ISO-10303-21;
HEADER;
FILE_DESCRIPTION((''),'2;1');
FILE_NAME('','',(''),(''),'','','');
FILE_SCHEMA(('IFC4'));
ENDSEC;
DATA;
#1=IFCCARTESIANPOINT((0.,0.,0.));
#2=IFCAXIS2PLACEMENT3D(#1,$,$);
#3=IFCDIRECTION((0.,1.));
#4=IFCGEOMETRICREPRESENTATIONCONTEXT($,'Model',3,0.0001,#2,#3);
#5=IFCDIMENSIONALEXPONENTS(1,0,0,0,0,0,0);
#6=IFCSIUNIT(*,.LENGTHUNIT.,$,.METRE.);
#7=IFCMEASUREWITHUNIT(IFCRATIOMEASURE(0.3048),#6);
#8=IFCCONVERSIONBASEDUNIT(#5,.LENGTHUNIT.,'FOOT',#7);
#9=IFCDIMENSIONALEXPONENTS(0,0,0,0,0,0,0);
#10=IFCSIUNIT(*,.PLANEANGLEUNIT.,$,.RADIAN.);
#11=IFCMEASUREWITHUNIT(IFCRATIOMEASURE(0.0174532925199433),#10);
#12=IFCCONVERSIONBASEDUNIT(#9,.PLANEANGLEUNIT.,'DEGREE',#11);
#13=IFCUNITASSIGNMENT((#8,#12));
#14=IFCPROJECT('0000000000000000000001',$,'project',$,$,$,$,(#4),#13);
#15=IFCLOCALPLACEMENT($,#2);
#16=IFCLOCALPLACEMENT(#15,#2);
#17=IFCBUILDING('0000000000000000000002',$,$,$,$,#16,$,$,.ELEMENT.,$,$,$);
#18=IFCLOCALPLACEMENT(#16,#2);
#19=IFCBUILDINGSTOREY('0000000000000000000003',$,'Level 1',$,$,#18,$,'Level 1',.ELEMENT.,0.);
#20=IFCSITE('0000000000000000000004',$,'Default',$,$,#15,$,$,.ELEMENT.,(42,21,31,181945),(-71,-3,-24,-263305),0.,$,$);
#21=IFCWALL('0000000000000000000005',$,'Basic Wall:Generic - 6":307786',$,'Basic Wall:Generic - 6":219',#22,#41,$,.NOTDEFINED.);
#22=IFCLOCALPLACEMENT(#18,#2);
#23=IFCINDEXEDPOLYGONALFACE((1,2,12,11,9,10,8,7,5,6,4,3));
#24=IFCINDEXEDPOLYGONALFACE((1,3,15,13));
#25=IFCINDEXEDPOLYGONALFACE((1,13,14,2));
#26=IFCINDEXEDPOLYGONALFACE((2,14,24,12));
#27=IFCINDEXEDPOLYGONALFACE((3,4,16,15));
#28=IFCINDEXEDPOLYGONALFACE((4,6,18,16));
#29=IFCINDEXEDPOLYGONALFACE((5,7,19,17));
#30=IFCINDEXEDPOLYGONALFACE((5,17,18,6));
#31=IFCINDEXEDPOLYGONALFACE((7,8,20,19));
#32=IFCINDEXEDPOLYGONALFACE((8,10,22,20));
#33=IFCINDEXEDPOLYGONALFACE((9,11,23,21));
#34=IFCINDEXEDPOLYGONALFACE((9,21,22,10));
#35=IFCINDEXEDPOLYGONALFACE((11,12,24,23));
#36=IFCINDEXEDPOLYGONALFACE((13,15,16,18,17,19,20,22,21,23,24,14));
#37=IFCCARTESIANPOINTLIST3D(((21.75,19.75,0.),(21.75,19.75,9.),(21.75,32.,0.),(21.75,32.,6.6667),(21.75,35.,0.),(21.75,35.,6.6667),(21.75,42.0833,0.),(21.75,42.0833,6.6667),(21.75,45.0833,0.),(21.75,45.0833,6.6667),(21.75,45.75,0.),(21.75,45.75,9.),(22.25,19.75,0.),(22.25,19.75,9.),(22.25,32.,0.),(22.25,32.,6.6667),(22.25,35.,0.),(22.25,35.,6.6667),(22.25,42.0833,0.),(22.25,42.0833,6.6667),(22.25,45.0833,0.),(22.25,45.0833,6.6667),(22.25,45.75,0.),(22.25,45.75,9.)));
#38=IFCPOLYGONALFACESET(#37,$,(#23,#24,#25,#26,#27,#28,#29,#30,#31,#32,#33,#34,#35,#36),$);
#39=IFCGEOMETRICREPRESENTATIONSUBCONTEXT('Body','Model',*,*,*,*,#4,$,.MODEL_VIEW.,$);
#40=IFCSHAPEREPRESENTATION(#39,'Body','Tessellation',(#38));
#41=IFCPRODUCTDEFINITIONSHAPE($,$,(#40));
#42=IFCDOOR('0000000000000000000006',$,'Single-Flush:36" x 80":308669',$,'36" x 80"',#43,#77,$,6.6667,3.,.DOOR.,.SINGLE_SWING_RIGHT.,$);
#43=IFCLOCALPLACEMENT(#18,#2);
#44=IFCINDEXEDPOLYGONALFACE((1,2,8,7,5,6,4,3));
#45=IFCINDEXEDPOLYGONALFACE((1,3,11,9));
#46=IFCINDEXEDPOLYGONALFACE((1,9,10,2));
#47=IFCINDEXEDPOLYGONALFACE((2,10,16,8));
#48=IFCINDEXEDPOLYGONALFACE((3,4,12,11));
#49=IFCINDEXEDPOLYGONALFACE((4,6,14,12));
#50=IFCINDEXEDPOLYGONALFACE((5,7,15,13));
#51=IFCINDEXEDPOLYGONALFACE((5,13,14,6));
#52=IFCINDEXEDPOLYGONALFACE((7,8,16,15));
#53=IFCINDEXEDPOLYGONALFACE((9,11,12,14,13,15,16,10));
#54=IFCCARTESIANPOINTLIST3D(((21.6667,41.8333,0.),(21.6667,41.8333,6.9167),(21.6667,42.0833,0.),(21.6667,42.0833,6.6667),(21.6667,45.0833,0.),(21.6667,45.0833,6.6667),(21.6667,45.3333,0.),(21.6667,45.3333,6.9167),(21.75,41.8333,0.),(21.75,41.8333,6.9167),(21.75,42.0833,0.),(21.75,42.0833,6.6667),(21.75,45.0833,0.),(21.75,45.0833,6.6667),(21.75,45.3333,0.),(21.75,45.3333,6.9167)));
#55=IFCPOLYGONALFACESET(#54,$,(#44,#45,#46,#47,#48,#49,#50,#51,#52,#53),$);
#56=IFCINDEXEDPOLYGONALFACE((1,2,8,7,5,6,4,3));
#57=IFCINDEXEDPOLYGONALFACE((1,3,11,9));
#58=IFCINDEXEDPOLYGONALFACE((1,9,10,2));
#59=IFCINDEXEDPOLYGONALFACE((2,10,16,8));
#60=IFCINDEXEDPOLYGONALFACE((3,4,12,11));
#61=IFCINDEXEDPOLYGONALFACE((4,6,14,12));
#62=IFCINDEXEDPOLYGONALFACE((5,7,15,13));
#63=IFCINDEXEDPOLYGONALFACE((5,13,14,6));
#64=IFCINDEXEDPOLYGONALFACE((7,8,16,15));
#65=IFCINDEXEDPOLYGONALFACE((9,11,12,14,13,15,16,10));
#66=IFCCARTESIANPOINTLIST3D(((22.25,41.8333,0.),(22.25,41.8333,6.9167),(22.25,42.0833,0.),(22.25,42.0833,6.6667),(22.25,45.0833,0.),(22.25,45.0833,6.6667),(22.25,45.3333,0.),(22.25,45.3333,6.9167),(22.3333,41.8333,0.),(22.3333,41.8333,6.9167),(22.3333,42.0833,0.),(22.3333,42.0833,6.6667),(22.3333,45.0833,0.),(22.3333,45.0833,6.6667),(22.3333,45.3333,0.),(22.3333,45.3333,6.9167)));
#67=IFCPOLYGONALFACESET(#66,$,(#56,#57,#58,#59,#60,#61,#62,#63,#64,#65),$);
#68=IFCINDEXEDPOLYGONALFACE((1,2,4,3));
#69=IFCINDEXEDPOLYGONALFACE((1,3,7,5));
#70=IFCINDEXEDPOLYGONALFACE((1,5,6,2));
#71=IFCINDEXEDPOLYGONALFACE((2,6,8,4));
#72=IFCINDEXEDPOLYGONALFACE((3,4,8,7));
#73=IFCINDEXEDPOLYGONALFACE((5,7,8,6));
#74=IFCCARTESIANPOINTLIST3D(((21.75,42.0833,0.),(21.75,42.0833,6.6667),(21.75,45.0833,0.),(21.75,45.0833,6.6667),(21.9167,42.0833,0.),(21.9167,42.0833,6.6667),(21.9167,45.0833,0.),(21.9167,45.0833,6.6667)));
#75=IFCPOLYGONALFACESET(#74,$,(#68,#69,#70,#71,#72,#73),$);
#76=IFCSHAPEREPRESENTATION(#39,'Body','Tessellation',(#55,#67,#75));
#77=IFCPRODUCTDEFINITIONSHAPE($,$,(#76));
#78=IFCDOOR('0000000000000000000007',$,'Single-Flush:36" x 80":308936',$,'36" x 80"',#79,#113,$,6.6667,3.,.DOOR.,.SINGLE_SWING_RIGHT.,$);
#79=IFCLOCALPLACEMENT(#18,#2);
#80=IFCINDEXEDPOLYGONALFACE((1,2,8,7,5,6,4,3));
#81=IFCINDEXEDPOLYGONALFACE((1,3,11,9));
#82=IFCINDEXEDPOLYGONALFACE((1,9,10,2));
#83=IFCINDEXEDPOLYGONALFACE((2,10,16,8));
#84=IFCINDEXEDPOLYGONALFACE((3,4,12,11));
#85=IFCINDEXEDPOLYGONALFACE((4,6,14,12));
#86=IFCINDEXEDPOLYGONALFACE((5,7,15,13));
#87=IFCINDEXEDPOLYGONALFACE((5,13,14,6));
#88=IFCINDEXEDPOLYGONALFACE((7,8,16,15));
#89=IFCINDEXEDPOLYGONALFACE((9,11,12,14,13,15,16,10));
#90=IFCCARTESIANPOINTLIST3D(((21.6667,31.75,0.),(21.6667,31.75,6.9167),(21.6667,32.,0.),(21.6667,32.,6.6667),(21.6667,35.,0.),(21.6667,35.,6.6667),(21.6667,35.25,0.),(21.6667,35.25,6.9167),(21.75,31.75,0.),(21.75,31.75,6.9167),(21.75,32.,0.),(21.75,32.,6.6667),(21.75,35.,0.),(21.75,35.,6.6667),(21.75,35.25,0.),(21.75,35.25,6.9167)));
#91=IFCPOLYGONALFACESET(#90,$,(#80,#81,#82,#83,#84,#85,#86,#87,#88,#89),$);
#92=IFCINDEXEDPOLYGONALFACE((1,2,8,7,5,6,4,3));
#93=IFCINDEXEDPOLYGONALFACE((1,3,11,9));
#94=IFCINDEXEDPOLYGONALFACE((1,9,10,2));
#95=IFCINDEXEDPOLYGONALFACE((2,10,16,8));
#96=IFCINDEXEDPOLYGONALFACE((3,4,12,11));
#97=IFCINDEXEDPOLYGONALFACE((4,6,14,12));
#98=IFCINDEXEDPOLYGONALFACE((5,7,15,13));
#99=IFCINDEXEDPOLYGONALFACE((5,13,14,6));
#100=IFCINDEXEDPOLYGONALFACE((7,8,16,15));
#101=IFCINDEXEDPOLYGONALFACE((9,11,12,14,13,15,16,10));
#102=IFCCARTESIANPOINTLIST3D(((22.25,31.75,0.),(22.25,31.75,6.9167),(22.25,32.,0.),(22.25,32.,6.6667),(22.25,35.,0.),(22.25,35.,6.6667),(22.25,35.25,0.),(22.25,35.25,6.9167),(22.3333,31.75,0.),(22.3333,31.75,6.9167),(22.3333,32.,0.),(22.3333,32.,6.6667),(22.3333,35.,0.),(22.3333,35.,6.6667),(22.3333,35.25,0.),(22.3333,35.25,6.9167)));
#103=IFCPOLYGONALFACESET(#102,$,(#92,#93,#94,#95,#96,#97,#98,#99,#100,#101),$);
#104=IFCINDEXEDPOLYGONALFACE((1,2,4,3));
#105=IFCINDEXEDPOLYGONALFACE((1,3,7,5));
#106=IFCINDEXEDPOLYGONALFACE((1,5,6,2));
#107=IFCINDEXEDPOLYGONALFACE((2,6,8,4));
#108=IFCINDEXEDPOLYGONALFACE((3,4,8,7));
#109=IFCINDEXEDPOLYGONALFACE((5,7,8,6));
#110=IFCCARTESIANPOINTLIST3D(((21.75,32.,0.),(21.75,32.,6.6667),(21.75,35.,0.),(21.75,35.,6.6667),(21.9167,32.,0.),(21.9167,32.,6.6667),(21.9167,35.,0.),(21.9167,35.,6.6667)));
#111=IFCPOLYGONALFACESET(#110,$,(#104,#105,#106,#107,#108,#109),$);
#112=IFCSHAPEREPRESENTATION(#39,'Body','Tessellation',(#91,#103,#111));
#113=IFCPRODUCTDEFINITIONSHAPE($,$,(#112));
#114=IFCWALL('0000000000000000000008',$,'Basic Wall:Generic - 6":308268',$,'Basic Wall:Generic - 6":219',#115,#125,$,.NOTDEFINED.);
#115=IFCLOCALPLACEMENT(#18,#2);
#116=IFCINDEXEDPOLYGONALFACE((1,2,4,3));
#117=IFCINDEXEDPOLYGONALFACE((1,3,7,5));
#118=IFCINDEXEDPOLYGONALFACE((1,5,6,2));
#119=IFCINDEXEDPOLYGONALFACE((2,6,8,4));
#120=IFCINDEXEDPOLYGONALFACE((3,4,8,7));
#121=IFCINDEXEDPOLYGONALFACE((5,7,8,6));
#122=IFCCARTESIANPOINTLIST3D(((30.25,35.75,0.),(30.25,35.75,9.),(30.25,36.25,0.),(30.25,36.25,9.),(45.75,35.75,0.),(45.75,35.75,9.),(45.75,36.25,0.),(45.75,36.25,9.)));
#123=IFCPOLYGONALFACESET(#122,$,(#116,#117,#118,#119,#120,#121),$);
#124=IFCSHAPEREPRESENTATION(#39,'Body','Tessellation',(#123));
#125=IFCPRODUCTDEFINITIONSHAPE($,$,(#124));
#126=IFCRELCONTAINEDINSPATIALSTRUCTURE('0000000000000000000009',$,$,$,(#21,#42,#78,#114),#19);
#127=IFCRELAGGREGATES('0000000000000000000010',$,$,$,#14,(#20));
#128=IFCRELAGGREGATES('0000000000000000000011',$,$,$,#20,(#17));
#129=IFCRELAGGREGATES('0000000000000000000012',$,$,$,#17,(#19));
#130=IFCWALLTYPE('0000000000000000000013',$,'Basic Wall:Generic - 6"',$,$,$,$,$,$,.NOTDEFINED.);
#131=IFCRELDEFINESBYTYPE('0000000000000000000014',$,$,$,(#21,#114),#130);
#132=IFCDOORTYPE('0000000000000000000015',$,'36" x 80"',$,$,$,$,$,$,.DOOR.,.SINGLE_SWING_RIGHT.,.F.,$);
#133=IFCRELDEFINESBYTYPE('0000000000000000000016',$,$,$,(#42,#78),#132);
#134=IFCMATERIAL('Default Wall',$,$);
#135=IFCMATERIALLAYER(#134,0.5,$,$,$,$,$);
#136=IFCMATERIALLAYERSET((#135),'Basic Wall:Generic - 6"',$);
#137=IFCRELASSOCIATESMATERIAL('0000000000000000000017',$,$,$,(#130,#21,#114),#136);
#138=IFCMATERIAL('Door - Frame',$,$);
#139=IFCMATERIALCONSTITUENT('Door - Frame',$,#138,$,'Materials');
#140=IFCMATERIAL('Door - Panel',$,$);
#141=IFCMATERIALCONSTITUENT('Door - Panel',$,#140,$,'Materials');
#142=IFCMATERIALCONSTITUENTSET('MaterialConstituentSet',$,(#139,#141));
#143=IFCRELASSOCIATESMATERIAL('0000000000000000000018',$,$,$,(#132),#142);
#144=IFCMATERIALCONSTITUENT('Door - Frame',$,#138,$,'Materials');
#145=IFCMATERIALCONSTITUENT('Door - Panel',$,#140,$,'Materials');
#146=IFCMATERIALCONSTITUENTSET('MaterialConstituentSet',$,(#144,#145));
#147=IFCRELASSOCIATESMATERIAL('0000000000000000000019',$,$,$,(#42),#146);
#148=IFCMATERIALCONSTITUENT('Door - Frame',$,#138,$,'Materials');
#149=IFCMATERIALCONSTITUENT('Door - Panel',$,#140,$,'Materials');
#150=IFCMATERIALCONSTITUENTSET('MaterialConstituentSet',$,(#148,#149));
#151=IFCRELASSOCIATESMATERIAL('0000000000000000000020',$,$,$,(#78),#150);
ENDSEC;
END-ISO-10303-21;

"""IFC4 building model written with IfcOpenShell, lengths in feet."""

from ifc_helpers import new_model, entity, si_unit, converted_unit, direction, frame, frame_2d, origin, origin_2d_with_axis, place, context, subcontext, project, spatial, polyline, rectangle, outline, extrude, clip, bounded_halfspace, source, transform, mapped, material, layer, layer_set, layer_usage, constituent, constituent_set, type_object, type_shapes, element, fill, save


model = new_model("IFC4")

# Units and contexts
model_context = context("Model", 3, precision=0.0001, world=origin(), true_north=direction((0.0, 1.0)))
body_context = subcontext(model_context, "Body", "Model", "MODEL_VIEW")
ifc_project = project(units=[converted_unit("LENGTHUNIT", "FOOT", entity("IfcRatioMeasure", 0.3048), si_unit("LENGTHUNIT", "METRE"), dimensions=[1, 0, 0, 0, 0, 0, 0]), converted_unit("PLANEANGLEUNIT", "DEGREE", entity("IfcRatioMeasure", 0.0174532925199433), si_unit("PLANEANGLEUNIT", "RADIAN"), dimensions=[0, 0, 0, 0, 0, 0, 0])], contexts=[model_context])

# Site, building, storey
site_placement = place(None, origin())
site = spatial("IfcSite", under=ifc_project, at=site_placement, Name="Default", CompositionType="ELEMENT", RefLatitude=(42, 21, 31, 181945), RefLongitude=(-71, -3, -24, -263305), RefElevation=0.0)
building_placement = place(site_placement, origin())
building = spatial("IfcBuilding", under=site, at=building_placement, CompositionType="ELEMENT")
storey_placement = place(building_placement, origin())
storey = spatial("IfcBuildingStorey", under=building, at=storey_placement, Name="Level 1", LongName="Level 1", CompositionType="ELEMENT", Elevation=0.0)

# Shared definitions
ifc_material_1 = material(Name="Default Wall")
ifc_layer = layer(ifc_material_1, 0.5)
ifc_layer_set = layer_set([ifc_layer], Name="Basic Wall:Generic - 6\"")
wall_type = type_object("IfcWallType", Name="Basic Wall:Generic - 6\"", PredefinedType="NOTDEFINED", material=ifc_layer_set)
ifc_material_2 = material(Name="Door - Frame")
ifc_material_3 = material(Name="Door - Panel")
ifc_constituent_1 = constituent(ifc_material_2, Name="Door - Frame", Category="Materials")
ifc_constituent_2 = constituent(ifc_material_3, Name="Door - Panel", Category="Materials")
ifc_constituent_set_1 = constituent_set(constituents=[ifc_constituent_1, ifc_constituent_2], Name="MaterialConstituentSet")
door_type_1 = type_object("IfcDoorType", Name="36\" x 80\"", OperationType="SINGLE_SWING_RIGHT", ParameterTakesPrecedence=False, PredefinedType="DOOR", material=ifc_constituent_set_1)
shared_shape_1 = source(origin(), body_context, "Body", "SweptSolid", [
    extrude(outline(polyline([(-1.75, -3.5208), (1.75, -3.5208), (1.75, 3.3958), (1.5, 3.3958), (1.5, -3.2708), (-1.5, -3.2708), (-1.5, 3.3958), (-1.75, 3.3958), (-1.75, -3.5208)])), frame((1.5, 0.5, 3.3958), z_axis=(0.0, 1.0, 0.0), x_axis=(1.0, 0.0, 0.0)), (0.0, 0.0, 1.0), 0.0833),
    extrude(outline(polyline([(-3.5208, -1.75), (3.3958, -1.75), (3.3958, -1.5), (-3.2708, -1.5), (-3.2708, 1.5), (3.3958, 1.5), (3.3958, 1.75), (-3.5208, 1.75), (-3.5208, -1.75)])), frame((1.5, -0.0833, 3.3958), z_axis=(0.0, 1.0, 0.0), x_axis=(0.0, 0.0, -1.0)), (0.0, 0.0, 1.0), 0.0833),
    extrude(rectangle(XDim=0.1667, YDim=3.0, at=origin_2d_with_axis()), frame((1.5, 0.4167, 0.0), z_axis=(0.0, 0.0, 1.0), x_axis=(0.0, 1.0, 0.0)), (0.0, 0.0, 1.0), 6.6667),
])
type_shapes(door_type_1, [shared_shape_1])

# Wall, openings, doors
ifc_layer_usage_1 = layer_usage(ifc_layer_set, "AXIS2", "NEGATIVE", 0.25)
wall_1_placement = place(storey_placement, frame((22.0, 45.75, 0.0), z_axis=(0.0, 0.0, 1.0), x_axis=(0.0, -1.0, 0.0)))
wall_1 = element("IfcWall", 1, at=wall_1_placement, inside=storey, type_object=wall_type, material=ifc_layer_usage_1, Name="Basic Wall:Generic - 6\":307786", ObjectType="Basic Wall:Generic - 6\":219", PredefinedType="NOTDEFINED", context=body_context, shape_type="Clipping", body=[
    clip(clip(extrude(rectangle(XDim=26.0, YDim=0.5, at=frame_2d((13.0, 0.0), x_axis=(-1.0, 0.0))), origin(), (0.0, 0.0, 1.0), 9.0), bounded_halfspace(frame((10.0, -0.25, 9.0), z_axis=(0.0, 0.0, -1.0), x_axis=(0.0, -1.0, 0.0)), True, frame((10.0, -0.25, 9.0)), polyline([(0.0, 0.0), (0.0, 0.5), (-10.0, 0.5), (-10.0, 0.0), (-0.5, 0.0), (0.0, 0.0)]))), bounded_halfspace(frame((10.0, -0.25, 9.0), z_axis=(0.0, 0.0, -1.0), x_axis=(-1.0, 0.0, 0.0)), True, frame((10.0, -0.25, 9.0)), polyline([(0.0, 0.0), (15.5, 0.0), (16.0, 0.0), (16.0, 0.5), (0.0, 0.5), (0.0, 0.0)]))),
])
opening_1_placement = place(wall_1_placement, frame((3.6667, 0.25, 0.0)))
opening_1 = element("IfcOpeningElement", 2, at=opening_1_placement, cuts=wall_1, ObjectType="Opening", PredefinedType="OPENING", context=body_context, shape_type="SweptSolid", body=[
    extrude(rectangle(XDim=3.0, YDim=6.6667, at=frame_2d((3.3333, 1.5), x_axis=(0.0, 1.0))), frame((0.0, 0.0, 0.0), z_axis=(0.0, -1.0, 0.0), x_axis=(0.0, 0.0, 1.0)), (0.0, 0.0, 1.0), 0.5),
])
opening_2_placement = place(wall_1_placement, frame((13.75, 0.25, 0.0)))
opening_2 = element("IfcOpeningElement", 3, at=opening_2_placement, cuts=wall_1, ObjectType="Opening", PredefinedType="OPENING", context=body_context, shape_type="SweptSolid", body=[
    extrude(rectangle(XDim=3.0, YDim=6.6667, at=frame_2d((3.3333, 1.5), x_axis=(0.0, 1.0))), frame((0.0, 0.0, 0.0), z_axis=(0.0, -1.0, 0.0), x_axis=(0.0, 0.0, 1.0)), (0.0, 0.0, 1.0), 0.5),
])
ifc_constituent_3 = constituent(ifc_material_2, Name="Door - Frame", Category="Materials")
ifc_constituent_4 = constituent(ifc_material_3, Name="Door - Panel", Category="Materials")
ifc_constituent_set_2 = constituent_set(constituents=[ifc_constituent_3, ifc_constituent_4], Name="MaterialConstituentSet")
door_1_placement = place(opening_1_placement, frame((0.0, 0.0, 0.0), z_axis=(0.0, 0.0, 1.0), x_axis=(-1.0, 0.0, 0.0)))
door_1 = element("IfcDoor", 4, at=door_1_placement, inside=storey, type_object=door_type_1, material=ifc_constituent_set_2, Name="Single-Flush:36\" x 80\":308669", ObjectType="36\" x 80\"", OperationType="SINGLE_SWING_RIGHT", OverallHeight=6.6667, OverallWidth=3.0, PredefinedType="DOOR", context=body_context, shape_type="MappedRepresentation", body=[
    mapped(shared_shape_1, transform((0.0, 0.0, 0.0), scale=1.0)),
])
fill(opening_1, door_1)
ifc_constituent_5 = constituent(ifc_material_2, Name="Door - Frame", Category="Materials")
ifc_constituent_6 = constituent(ifc_material_3, Name="Door - Panel", Category="Materials")
ifc_constituent_set_3 = constituent_set(constituents=[ifc_constituent_5, ifc_constituent_6], Name="MaterialConstituentSet")
door_2_placement = place(opening_2_placement, frame((0.0, 0.0, 0.0), z_axis=(0.0, 0.0, 1.0), x_axis=(-1.0, 0.0, 0.0)))
door_2 = element("IfcDoor", 5, at=door_2_placement, inside=storey, type_object=door_type_1, material=ifc_constituent_set_3, Name="Single-Flush:36\" x 80\":308936", ObjectType="36\" x 80\"", OperationType="SINGLE_SWING_RIGHT", OverallHeight=6.6667, OverallWidth=3.0, PredefinedType="DOOR", context=body_context, shape_type="MappedRepresentation", body=[
    mapped(shared_shape_1, transform((0.0, 0.0, 0.0), scale=1.0)),
])
fill(opening_2, door_2)

# Wall
ifc_layer_usage_2 = layer_usage(ifc_layer_set, "AXIS2", "NEGATIVE", 0.25)
wall_2_placement = place(storey_placement, frame((30.25, 36.0, 0.0)))
element("IfcWall", 6, at=wall_2_placement, inside=storey, type_object=wall_type, material=ifc_layer_usage_2, Name="Basic Wall:Generic - 6\":308268", ObjectType="Basic Wall:Generic - 6\":219", PredefinedType="NOTDEFINED", context=body_context, shape_type="Clipping", body=[
    clip(extrude(rectangle(XDim=15.5, YDim=0.5, at=frame_2d((7.75, 0.0), x_axis=(-1.0, 0.0))), origin(), (0.0, 0.0, 1.0), 9.0), bounded_halfspace(frame((0.0, -0.25, 9.0), z_axis=(0.0, 0.0, -1.0), x_axis=(1.0, 0.0, 0.0)), True, frame((0.0, -0.25, 9.0)), polyline([(0.0, 0.0), (15.5, 0.0), (15.5, 0.5), (0.0, 0.5), (0.0, 0.0)]))),
])

save(model, "model.ifc")
